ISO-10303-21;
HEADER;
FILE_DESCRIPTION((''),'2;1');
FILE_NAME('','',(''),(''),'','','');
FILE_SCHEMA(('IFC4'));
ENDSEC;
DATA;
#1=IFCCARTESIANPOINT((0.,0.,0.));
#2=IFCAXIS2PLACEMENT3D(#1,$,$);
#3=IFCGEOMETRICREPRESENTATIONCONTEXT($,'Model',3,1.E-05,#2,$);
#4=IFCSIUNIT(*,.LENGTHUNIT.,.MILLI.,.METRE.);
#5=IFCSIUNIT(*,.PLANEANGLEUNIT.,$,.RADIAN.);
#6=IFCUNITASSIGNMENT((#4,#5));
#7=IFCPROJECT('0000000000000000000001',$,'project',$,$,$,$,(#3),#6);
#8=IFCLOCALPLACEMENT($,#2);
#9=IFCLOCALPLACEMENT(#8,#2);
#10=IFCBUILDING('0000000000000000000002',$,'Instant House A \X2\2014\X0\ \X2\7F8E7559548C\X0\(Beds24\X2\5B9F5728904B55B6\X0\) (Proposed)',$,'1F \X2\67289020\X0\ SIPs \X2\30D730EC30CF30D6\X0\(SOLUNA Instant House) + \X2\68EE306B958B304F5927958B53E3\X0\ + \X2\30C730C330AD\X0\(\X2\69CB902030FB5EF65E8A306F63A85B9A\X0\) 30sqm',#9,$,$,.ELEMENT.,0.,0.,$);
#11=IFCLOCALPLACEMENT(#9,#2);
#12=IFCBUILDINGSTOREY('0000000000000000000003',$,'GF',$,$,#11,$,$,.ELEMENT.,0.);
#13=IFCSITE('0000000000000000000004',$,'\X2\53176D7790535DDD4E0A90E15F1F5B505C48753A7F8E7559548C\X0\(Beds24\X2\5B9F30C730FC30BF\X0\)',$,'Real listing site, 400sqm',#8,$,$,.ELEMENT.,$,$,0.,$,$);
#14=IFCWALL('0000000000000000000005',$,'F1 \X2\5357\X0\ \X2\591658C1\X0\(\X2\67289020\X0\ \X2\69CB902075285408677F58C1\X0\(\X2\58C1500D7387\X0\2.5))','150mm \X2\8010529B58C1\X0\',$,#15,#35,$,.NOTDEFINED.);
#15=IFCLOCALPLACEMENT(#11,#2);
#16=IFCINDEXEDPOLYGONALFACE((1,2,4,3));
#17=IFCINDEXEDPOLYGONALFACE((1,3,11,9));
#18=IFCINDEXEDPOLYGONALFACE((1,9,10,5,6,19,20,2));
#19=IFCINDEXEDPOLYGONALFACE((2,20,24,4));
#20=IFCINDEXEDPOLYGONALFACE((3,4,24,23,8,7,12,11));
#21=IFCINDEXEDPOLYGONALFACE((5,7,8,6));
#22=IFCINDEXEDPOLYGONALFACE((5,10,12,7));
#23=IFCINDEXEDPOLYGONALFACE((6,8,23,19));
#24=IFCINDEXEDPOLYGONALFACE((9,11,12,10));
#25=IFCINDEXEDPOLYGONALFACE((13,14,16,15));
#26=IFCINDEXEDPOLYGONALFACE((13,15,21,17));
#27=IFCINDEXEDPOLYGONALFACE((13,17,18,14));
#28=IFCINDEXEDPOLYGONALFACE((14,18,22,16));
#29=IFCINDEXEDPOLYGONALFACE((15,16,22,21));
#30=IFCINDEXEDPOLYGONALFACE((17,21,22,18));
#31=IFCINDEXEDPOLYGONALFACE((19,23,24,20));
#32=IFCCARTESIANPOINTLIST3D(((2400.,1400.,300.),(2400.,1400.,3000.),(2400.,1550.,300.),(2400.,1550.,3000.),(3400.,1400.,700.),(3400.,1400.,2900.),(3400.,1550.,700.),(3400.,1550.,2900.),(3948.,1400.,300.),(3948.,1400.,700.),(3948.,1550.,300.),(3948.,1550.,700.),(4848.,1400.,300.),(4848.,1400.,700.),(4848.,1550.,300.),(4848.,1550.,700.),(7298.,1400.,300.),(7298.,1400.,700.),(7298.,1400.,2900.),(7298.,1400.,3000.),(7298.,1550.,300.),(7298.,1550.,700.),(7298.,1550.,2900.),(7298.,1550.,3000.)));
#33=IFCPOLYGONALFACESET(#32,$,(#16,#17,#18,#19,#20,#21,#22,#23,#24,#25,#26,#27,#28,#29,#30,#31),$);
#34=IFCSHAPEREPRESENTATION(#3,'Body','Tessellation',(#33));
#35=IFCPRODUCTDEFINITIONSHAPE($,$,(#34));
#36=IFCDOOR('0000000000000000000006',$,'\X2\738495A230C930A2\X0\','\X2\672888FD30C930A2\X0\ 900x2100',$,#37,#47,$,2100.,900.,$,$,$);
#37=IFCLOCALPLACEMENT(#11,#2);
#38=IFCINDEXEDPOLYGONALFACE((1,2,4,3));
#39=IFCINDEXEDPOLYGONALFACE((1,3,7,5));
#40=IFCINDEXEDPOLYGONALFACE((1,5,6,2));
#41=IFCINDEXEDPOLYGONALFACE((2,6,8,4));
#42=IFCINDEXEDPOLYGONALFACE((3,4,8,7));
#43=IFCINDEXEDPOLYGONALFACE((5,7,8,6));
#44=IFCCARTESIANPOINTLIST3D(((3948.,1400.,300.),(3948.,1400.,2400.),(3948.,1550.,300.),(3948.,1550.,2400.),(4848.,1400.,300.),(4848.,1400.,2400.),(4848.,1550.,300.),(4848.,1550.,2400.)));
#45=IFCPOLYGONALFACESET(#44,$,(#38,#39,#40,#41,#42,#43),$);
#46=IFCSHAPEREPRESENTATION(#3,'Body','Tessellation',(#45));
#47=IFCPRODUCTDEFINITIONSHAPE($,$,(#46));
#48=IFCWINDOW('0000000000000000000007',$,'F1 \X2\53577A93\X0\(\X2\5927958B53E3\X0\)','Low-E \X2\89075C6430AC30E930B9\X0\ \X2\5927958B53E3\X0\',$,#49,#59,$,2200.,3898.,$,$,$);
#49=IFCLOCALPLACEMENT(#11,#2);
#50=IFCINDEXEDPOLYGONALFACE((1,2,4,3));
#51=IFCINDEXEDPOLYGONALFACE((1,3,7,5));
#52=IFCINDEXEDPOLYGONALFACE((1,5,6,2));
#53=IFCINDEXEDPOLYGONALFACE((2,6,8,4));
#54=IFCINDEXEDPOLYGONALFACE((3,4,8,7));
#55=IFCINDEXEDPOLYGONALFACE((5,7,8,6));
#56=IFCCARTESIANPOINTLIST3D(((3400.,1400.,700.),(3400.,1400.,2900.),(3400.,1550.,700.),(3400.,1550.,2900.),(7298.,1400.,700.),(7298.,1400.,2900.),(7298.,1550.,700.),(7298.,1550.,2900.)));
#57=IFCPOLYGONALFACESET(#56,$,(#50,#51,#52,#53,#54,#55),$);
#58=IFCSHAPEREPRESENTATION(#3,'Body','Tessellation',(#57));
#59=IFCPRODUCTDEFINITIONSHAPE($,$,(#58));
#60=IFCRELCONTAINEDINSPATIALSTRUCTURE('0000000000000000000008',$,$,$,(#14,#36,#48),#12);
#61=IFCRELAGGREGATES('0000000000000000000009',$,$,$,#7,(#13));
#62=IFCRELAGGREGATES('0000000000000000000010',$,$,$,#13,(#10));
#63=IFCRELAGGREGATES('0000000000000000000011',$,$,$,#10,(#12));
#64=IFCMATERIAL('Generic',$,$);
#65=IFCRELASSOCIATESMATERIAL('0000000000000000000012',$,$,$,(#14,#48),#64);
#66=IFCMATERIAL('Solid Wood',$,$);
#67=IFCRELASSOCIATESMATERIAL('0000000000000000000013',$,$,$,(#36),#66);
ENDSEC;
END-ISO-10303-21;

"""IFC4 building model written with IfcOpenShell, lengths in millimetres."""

from ifc_helpers import new_model, si_unit, frame, frame_2d, origin, place, context, project, spatial, rectangle, extrude, material, element, fill, save


model = new_model("IFC4")

# Units and contexts
model_context = context("Model", 3, precision=1e-05, world=origin())
ifc_project = project(units=[si_unit("LENGTHUNIT", "METRE", prefix="MILLI"), si_unit("PLANEANGLEUNIT", "RADIAN")], contexts=[model_context])

# Site, building, storey
site_placement = place(None, origin())
site = spatial("IfcSite", under=ifc_project, at=site_placement, Name="北海道川上郡弟子屈町美留和(Beds24実データ)", ObjectType="Real listing site, 400sqm", CompositionType="ELEMENT", RefElevation=0.0)
building_placement = place(site_placement, origin())
building = spatial("IfcBuilding", under=site, at=building_placement, Name="Instant House A — 美留和(Beds24実在運営) (Proposed)", ObjectType="1F 木造 SIPs プレハブ(SOLUNA Instant House) + 森に開く大開口 + デッキ(構造・延床は推定) 30sqm", CompositionType="ELEMENT", ElevationOfRefHeight=0.0, ElevationOfTerrain=0.0)
storey_placement = place(building_placement, origin())
storey = spatial("IfcBuildingStorey", under=building, at=storey_placement, Name="GF", CompositionType="ELEMENT", Elevation=0.0)

# Shared definitions
ifc_material_1 = material(Name="Generic")

# Wall, openings, door, window
wall_1_placement = place(storey_placement, frame((1200.0, 700.0, 150.0)))
wall_1 = element("IfcWall", 1, at=wall_1_placement, inside=storey, material=ifc_material_1, Name="F1 南 外壁(木造 構造用合板壁(壁倍率2.5))", Description="150mm 耐力壁", PredefinedType="NOTDEFINED", context=model_context, shape_type="SweptSolid", body=[
    extrude(rectangle(XDim=4898.0, YDim=150.0, at=frame_2d((2449.0, 75.0))), frame((1200.0, 700.0, 150.0)), (0.0, 0.0, 1.0), 2700.0),
])
opening_1_placement = place(storey_placement, frame((1974.0, 700.0, 150.0)))
opening_1 = element("IfcOpeningElement", 2, at=opening_1_placement, cuts=wall_1, PredefinedType="NOTDEFINED", context=model_context, shape_type="SweptSolid", body=[
    extrude(rectangle(XDim=900.0, YDim=150.0, at=frame_2d((450.0, 75.0))), frame((1974.0, 700.0, 150.0)), (0.0, 0.0, 1.0), 2100.0),
])
opening_2_placement = place(storey_placement, frame((1700.0, 700.0, 350.0)))
opening_2 = element("IfcOpeningElement", 3, at=opening_2_placement, cuts=wall_1, PredefinedType="NOTDEFINED", context=model_context, shape_type="SweptSolid", body=[
    extrude(rectangle(XDim=3898.0, YDim=150.0, at=frame_2d((1949.0, 75.0))), frame((1700.0, 700.0, 350.0)), (0.0, 0.0, 1.0), 2200.0),
])
ifc_material_2 = material(Name="Solid Wood")
door_placement = place(storey_placement, frame((1974.0, 700.0, 150.0)))
door = element("IfcDoor", 4, at=door_placement, inside=storey, material=ifc_material_2, Name="玄関ドア", Description="木製ドア 900x2100", OverallHeight=2100.0, OverallWidth=900.0, context=model_context, shape_type="SweptSolid", body=[
    extrude(rectangle(XDim=900.0, YDim=150.0, at=frame_2d((450.0, 75.0))), frame((1974.0, 700.0, 150.0)), (0.0, 0.0, 1.0), 2100.0),
])
fill(opening_1, door)
window_1_placement = place(storey_placement, frame((1700.0, 700.0, 350.0)))
window_1 = element("IfcWindow", 5, at=window_1_placement, inside=storey, material=ifc_material_1, Name="F1 南窓(大開口)", Description="Low-E 複層ガラス 大開口", OverallHeight=2200.0, OverallWidth=3898.0, context=model_context, shape_type="SweptSolid", body=[
    extrude(rectangle(XDim=3898.0, YDim=150.0, at=frame_2d((1949.0, 75.0))), frame((1700.0, 700.0, 350.0)), (0.0, 0.0, 1.0), 2200.0),
])
fill(opening_2, window_1)

save(model, "model.ifc")
